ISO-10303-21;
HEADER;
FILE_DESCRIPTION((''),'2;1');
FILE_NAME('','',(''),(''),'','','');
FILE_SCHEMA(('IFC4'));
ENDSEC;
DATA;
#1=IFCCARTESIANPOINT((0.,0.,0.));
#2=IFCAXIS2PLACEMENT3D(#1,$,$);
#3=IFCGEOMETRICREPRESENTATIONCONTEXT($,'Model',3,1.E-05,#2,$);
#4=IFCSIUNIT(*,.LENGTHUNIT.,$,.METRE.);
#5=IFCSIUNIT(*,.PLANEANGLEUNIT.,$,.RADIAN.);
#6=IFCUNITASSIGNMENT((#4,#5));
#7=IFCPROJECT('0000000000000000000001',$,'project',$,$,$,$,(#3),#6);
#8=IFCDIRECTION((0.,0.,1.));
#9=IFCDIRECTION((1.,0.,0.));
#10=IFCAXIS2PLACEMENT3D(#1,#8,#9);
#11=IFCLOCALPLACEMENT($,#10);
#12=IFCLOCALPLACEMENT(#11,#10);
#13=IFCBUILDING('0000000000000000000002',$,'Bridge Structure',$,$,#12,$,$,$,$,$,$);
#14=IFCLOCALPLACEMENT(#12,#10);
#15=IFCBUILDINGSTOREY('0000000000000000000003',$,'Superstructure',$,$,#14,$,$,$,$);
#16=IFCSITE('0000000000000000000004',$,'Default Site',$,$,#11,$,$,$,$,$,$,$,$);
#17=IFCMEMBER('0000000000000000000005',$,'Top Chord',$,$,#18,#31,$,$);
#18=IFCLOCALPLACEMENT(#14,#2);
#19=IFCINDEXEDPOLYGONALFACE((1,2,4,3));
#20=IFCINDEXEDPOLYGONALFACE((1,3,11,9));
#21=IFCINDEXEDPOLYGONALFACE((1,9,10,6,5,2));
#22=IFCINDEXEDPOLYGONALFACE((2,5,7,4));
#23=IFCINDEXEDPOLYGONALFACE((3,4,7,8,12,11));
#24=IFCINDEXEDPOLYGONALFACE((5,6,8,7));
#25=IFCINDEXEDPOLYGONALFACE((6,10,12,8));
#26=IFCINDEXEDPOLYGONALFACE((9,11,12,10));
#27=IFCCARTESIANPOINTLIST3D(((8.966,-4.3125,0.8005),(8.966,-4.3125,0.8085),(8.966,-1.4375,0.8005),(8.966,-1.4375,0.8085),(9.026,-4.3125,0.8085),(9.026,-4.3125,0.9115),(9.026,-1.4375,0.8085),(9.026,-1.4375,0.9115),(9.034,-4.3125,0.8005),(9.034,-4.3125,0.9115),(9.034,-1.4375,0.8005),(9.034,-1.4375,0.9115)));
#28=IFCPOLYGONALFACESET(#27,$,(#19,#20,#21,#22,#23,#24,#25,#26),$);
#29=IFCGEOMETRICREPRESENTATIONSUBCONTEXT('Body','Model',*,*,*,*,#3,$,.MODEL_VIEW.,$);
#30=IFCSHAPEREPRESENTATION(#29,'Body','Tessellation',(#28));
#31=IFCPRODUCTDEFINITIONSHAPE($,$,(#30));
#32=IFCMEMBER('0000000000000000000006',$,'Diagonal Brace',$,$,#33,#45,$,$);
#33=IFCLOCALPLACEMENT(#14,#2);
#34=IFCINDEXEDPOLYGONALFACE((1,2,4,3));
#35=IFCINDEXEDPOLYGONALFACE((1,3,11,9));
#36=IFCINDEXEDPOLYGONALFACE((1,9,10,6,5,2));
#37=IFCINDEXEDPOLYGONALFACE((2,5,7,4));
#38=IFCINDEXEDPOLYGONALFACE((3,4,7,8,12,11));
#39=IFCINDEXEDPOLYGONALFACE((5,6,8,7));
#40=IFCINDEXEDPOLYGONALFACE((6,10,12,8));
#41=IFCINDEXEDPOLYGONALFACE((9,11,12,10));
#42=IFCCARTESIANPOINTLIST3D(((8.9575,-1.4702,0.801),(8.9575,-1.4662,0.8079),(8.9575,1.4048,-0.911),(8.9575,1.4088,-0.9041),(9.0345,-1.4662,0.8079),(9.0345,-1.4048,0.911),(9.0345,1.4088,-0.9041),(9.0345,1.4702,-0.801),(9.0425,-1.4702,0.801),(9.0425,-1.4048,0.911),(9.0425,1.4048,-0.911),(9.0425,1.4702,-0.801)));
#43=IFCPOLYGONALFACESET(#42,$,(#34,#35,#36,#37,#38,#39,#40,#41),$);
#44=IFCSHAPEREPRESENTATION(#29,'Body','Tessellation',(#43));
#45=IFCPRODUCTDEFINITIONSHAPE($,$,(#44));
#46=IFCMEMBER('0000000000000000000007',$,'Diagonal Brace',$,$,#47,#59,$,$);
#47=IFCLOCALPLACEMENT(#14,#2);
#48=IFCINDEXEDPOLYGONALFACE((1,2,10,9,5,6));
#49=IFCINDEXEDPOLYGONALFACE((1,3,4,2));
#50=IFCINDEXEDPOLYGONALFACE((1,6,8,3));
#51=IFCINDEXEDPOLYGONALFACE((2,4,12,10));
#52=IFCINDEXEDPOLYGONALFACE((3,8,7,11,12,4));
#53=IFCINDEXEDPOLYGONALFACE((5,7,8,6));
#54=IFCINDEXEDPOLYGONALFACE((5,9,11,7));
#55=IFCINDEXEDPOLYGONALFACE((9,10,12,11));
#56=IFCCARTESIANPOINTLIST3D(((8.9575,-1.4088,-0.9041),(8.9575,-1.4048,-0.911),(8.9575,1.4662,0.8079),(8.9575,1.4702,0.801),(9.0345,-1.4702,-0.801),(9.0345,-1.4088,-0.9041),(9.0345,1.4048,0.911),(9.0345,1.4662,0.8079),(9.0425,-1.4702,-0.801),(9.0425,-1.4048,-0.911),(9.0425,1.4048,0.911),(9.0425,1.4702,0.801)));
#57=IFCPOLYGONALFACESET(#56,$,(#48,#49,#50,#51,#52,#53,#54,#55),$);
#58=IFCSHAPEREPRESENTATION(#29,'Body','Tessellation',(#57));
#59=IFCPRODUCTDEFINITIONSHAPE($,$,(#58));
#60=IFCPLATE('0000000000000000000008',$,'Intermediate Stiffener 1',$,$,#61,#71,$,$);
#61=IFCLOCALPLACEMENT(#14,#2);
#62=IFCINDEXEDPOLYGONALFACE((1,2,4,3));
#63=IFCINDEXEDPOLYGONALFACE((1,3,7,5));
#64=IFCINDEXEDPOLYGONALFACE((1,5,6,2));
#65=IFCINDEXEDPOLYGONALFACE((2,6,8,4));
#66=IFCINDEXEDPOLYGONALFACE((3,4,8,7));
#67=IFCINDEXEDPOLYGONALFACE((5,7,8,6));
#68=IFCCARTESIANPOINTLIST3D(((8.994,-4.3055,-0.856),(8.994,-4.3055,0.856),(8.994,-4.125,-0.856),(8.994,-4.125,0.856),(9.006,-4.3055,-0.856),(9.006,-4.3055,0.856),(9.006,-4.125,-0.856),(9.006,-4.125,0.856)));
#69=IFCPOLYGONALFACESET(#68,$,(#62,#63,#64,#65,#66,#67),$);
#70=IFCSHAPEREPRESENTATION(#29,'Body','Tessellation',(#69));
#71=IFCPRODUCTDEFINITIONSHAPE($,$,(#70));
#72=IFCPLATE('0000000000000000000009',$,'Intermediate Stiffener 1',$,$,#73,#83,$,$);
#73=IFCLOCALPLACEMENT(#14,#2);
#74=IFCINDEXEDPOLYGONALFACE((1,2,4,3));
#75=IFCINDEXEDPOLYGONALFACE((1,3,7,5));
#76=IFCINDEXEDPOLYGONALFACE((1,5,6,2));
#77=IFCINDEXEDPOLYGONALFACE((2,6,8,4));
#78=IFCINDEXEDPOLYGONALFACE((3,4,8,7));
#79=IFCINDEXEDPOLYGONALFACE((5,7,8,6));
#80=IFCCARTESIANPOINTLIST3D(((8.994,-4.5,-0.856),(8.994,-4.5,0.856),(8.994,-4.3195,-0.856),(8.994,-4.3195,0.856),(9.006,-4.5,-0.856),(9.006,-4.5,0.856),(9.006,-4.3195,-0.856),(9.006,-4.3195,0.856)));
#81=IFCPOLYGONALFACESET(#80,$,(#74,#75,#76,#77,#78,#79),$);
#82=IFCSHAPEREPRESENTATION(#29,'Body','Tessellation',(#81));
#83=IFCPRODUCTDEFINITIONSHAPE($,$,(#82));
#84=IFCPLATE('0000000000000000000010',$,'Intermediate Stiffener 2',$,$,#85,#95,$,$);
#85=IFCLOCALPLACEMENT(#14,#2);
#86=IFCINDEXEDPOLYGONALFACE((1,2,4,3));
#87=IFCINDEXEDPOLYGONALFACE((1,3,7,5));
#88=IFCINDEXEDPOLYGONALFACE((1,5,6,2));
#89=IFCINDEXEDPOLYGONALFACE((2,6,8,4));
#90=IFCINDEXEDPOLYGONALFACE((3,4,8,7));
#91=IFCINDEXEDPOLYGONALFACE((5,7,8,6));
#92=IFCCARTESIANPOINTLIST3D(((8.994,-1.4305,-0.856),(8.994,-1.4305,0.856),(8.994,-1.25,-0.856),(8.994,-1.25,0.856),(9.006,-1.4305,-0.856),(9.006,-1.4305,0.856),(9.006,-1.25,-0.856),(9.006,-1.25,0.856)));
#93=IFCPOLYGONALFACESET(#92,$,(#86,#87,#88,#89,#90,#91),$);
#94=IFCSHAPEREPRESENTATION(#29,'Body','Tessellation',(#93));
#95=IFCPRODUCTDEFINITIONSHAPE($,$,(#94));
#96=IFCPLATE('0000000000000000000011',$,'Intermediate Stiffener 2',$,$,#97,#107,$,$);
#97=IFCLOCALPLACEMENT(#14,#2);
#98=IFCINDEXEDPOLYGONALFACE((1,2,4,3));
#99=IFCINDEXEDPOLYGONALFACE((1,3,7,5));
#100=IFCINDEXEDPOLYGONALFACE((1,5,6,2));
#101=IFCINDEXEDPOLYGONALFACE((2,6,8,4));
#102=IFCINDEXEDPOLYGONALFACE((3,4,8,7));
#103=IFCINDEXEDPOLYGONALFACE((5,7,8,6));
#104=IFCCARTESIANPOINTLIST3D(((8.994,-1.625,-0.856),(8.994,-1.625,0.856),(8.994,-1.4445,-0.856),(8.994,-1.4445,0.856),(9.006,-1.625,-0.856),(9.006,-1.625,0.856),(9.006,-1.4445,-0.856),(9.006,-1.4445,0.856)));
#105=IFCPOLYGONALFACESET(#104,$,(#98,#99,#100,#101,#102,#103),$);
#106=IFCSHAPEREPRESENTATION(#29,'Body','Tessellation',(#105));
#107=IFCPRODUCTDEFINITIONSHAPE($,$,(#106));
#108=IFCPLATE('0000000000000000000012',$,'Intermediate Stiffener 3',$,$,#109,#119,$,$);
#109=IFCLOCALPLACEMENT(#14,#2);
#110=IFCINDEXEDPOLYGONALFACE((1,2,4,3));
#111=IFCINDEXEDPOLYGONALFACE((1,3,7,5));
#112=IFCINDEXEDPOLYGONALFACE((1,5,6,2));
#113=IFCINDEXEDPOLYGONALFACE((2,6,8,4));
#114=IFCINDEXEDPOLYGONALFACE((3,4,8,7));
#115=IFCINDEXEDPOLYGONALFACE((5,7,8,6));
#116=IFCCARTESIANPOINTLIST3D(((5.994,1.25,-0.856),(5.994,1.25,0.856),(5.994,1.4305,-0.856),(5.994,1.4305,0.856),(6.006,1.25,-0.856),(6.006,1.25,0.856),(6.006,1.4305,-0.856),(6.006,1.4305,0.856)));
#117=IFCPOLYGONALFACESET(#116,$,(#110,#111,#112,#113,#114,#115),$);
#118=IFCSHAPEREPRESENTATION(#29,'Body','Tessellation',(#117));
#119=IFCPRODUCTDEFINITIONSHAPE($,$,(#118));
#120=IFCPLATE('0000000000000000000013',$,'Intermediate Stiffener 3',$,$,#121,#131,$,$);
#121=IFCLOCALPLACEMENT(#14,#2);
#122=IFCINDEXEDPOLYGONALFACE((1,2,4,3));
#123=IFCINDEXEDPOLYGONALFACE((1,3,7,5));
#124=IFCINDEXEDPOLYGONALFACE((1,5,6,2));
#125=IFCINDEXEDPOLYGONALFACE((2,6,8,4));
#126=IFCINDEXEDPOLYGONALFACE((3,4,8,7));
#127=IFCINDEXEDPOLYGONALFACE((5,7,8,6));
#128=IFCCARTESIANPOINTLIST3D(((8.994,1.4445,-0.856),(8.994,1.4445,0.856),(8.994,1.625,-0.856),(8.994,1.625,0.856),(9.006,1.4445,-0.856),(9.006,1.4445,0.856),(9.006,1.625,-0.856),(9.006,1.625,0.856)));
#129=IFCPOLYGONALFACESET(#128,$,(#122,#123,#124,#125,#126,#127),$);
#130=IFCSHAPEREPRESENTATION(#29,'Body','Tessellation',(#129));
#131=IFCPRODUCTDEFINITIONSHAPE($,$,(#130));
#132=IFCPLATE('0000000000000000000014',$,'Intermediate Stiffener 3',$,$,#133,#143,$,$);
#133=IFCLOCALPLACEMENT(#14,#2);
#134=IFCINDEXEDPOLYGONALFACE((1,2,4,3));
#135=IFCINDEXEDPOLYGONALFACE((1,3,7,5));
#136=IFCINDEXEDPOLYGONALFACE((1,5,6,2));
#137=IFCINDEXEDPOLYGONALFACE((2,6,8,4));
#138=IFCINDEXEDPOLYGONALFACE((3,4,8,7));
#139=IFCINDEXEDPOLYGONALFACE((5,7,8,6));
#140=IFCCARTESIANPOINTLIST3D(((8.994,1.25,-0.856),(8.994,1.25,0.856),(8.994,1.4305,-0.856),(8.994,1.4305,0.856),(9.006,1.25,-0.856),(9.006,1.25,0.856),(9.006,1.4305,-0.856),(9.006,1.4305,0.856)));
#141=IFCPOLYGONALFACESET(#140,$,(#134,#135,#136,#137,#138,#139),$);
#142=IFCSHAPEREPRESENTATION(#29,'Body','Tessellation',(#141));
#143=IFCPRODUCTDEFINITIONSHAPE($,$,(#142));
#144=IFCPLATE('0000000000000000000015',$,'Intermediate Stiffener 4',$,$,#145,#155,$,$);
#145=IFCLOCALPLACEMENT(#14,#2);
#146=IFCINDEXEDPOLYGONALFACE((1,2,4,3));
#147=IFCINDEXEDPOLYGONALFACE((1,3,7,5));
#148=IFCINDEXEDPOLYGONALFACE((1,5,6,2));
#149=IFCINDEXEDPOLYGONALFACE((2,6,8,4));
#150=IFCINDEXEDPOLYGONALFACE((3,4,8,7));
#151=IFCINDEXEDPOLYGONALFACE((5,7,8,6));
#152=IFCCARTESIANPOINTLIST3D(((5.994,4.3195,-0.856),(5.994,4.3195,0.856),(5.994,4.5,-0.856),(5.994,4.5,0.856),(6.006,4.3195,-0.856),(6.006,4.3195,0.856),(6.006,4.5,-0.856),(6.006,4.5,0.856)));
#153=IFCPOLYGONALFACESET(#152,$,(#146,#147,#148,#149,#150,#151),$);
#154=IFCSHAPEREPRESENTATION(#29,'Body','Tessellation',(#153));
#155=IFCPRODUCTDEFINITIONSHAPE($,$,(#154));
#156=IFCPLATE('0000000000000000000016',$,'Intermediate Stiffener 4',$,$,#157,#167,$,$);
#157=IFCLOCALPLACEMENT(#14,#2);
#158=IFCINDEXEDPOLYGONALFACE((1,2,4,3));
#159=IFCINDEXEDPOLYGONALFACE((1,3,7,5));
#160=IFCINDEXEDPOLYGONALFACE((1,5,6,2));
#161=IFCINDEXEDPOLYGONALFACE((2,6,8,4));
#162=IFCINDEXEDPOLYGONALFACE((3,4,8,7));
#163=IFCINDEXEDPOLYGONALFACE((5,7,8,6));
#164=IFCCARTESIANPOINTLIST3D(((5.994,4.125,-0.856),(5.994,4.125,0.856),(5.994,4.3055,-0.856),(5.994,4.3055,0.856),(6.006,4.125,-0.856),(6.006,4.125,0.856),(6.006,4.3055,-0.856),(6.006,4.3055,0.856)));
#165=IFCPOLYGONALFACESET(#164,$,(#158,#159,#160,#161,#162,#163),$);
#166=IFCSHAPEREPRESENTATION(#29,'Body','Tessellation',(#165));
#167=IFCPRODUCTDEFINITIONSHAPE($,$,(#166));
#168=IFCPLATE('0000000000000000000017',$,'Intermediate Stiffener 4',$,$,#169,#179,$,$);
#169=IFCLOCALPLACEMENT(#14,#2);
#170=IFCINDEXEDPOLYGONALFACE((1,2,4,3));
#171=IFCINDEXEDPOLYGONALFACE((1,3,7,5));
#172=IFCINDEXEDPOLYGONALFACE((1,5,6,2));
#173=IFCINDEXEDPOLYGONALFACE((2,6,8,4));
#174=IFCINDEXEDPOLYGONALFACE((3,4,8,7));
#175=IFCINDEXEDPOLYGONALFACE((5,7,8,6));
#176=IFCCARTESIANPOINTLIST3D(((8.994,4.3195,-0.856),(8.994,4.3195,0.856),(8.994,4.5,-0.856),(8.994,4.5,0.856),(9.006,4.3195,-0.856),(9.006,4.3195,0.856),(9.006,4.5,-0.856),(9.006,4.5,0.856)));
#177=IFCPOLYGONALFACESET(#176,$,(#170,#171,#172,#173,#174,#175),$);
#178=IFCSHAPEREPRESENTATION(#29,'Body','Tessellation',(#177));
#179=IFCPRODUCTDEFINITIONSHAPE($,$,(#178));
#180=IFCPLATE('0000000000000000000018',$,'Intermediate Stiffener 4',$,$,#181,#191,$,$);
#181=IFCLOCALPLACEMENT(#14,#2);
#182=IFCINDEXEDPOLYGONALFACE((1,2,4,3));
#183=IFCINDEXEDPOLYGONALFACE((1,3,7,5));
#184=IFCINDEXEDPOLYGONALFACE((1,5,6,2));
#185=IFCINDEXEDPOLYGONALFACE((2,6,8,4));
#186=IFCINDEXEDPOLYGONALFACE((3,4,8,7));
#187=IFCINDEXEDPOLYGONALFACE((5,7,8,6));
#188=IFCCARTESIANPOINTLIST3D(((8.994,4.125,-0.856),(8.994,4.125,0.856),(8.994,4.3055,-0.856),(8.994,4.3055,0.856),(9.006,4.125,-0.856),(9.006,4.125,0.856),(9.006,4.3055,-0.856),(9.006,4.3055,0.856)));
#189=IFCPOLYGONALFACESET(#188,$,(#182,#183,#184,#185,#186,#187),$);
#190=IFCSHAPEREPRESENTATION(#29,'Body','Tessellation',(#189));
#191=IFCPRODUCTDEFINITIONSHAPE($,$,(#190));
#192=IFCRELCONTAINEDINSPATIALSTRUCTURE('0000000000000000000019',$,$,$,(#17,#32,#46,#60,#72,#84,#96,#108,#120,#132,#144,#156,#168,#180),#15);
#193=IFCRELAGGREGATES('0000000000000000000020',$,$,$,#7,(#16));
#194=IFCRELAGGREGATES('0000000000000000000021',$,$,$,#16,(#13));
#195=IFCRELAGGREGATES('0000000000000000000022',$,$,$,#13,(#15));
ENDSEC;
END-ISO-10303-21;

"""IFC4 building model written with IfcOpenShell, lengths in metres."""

from ifc_helpers import new_model, si_unit, frame, origin, origin_with_axes, origin_2d_with_axis, place, context, subcontext, project, spatial, rectangle, l_section, extrude, element, save


model = new_model("IFC4")

# Units and contexts
model_context = context("Model", 3, precision=1e-05, world=origin())
body_context = subcontext(model_context, "Body", "Model", "MODEL_VIEW")
ifc_project = project(units=[si_unit("LENGTHUNIT", "METRE"), si_unit("PLANEANGLEUNIT", "RADIAN")], contexts=[model_context])

# Site, building, storey
site_placement = place(None, origin_with_axes())
site = spatial("IfcSite", under=ifc_project, at=site_placement, Name="Default Site")
building_placement = place(site_placement, origin_with_axes())
building = spatial("IfcBuilding", under=site, at=building_placement, Name="Bridge Structure")
storey_placement = place(building_placement, origin_with_axes())
storey = spatial("IfcBuildingStorey", under=building, at=storey_placement, Name="Superstructure")

# Members
for number, where, z_axis, x_axis, name in (
    (1, (9.0, -4.3125, 0.856), (0.0, 1.0, 0.0), (-1.0, 0.0, 0.0), "Top Chord"),
):
    element("IfcMember", number, at=place(storey_placement, frame(where, z_axis=z_axis, x_axis=x_axis)), inside=storey, Name=name, context=body_context, shape_type="SweptSolid", body=[
        extrude(l_section(Depth=0.111, Width=0.068, Thickness=0.008, at=origin_2d_with_axis()), origin_with_axes(), (0.0, 0.0, 1.0), 2.875),
    ])
for number, where, z_axis, x_axis, name in (
    (2, (9.0, -1.4375, 0.856), (0.0, 0.859202, -0.511636), (-1.0, 0.0, 0.0), "Diagonal Brace"),
    (3, (9.0, -1.4375, -0.856), (0.0, 0.859202, 0.511636), (-1.0, 0.0, 0.0), "Diagonal Brace"),
):
    element("IfcMember", number, at=place(storey_placement, frame(where, z_axis=z_axis, x_axis=x_axis)), inside=storey, Name=name, context=body_context, shape_type="SweptSolid", body=[
        extrude(l_section(Depth=0.128, Width=0.085, Thickness=0.008, at=origin_2d_with_axis()), origin_with_axes(), (0.0, 0.0, 1.0), 3.3461),
    ])

# Plates
for number, where, z_axis, x_axis, name in (
    (4, (9.0, -4.2153, -0.856), (0.0, 0.0, 1.0), (1.0, 0.0, 0.0), "Intermediate Stiffener 1"),
    (5, (9.0, -4.4097, -0.856), (0.0, 0.0, 1.0), (1.0, 0.0, 0.0), "Intermediate Stiffener 1"),
    (6, (9.0, -1.3402, -0.856), (0.0, 0.0, 1.0), (1.0, 0.0, 0.0), "Intermediate Stiffener 2"),
    (7, (9.0, -1.5348, -0.856), (0.0, 0.0, 1.0), (1.0, 0.0, 0.0), "Intermediate Stiffener 2"),
    (8, (6.0, 1.3402, -0.856), (0.0, 0.0, 1.0), (1.0, 0.0, 0.0), "Intermediate Stiffener 3"),
    (9, (9.0, 1.5348, -0.856), (0.0, 0.0, 1.0), (1.0, 0.0, 0.0), "Intermediate Stiffener 3"),
    (10, (9.0, 1.3402, -0.856), (0.0, 0.0, 1.0), (1.0, 0.0, 0.0), "Intermediate Stiffener 3"),
    (11, (6.0, 4.4097, -0.856), (0.0, 0.0, 1.0), (1.0, 0.0, 0.0), "Intermediate Stiffener 4"),
    (12, (6.0, 4.2153, -0.856), (0.0, 0.0, 1.0), (1.0, 0.0, 0.0), "Intermediate Stiffener 4"),
    (13, (9.0, 4.4097, -0.856), (0.0, 0.0, 1.0), (1.0, 0.0, 0.0), "Intermediate Stiffener 4"),
    (14, (9.0, 4.2153, -0.856), (0.0, 0.0, 1.0), (1.0, 0.0, 0.0), "Intermediate Stiffener 4"),
):
    element("IfcPlate", number, at=place(storey_placement, frame(where, z_axis=z_axis, x_axis=x_axis)), inside=storey, Name=name, context=body_context, shape_type="SweptSolid", body=[
        extrude(rectangle(XDim=0.012, YDim=0.1805, at=origin_2d_with_axis()), origin_with_axes(), (0.0, 0.0, 1.0), 1.712),
    ])

save(model, "model.ifc")
